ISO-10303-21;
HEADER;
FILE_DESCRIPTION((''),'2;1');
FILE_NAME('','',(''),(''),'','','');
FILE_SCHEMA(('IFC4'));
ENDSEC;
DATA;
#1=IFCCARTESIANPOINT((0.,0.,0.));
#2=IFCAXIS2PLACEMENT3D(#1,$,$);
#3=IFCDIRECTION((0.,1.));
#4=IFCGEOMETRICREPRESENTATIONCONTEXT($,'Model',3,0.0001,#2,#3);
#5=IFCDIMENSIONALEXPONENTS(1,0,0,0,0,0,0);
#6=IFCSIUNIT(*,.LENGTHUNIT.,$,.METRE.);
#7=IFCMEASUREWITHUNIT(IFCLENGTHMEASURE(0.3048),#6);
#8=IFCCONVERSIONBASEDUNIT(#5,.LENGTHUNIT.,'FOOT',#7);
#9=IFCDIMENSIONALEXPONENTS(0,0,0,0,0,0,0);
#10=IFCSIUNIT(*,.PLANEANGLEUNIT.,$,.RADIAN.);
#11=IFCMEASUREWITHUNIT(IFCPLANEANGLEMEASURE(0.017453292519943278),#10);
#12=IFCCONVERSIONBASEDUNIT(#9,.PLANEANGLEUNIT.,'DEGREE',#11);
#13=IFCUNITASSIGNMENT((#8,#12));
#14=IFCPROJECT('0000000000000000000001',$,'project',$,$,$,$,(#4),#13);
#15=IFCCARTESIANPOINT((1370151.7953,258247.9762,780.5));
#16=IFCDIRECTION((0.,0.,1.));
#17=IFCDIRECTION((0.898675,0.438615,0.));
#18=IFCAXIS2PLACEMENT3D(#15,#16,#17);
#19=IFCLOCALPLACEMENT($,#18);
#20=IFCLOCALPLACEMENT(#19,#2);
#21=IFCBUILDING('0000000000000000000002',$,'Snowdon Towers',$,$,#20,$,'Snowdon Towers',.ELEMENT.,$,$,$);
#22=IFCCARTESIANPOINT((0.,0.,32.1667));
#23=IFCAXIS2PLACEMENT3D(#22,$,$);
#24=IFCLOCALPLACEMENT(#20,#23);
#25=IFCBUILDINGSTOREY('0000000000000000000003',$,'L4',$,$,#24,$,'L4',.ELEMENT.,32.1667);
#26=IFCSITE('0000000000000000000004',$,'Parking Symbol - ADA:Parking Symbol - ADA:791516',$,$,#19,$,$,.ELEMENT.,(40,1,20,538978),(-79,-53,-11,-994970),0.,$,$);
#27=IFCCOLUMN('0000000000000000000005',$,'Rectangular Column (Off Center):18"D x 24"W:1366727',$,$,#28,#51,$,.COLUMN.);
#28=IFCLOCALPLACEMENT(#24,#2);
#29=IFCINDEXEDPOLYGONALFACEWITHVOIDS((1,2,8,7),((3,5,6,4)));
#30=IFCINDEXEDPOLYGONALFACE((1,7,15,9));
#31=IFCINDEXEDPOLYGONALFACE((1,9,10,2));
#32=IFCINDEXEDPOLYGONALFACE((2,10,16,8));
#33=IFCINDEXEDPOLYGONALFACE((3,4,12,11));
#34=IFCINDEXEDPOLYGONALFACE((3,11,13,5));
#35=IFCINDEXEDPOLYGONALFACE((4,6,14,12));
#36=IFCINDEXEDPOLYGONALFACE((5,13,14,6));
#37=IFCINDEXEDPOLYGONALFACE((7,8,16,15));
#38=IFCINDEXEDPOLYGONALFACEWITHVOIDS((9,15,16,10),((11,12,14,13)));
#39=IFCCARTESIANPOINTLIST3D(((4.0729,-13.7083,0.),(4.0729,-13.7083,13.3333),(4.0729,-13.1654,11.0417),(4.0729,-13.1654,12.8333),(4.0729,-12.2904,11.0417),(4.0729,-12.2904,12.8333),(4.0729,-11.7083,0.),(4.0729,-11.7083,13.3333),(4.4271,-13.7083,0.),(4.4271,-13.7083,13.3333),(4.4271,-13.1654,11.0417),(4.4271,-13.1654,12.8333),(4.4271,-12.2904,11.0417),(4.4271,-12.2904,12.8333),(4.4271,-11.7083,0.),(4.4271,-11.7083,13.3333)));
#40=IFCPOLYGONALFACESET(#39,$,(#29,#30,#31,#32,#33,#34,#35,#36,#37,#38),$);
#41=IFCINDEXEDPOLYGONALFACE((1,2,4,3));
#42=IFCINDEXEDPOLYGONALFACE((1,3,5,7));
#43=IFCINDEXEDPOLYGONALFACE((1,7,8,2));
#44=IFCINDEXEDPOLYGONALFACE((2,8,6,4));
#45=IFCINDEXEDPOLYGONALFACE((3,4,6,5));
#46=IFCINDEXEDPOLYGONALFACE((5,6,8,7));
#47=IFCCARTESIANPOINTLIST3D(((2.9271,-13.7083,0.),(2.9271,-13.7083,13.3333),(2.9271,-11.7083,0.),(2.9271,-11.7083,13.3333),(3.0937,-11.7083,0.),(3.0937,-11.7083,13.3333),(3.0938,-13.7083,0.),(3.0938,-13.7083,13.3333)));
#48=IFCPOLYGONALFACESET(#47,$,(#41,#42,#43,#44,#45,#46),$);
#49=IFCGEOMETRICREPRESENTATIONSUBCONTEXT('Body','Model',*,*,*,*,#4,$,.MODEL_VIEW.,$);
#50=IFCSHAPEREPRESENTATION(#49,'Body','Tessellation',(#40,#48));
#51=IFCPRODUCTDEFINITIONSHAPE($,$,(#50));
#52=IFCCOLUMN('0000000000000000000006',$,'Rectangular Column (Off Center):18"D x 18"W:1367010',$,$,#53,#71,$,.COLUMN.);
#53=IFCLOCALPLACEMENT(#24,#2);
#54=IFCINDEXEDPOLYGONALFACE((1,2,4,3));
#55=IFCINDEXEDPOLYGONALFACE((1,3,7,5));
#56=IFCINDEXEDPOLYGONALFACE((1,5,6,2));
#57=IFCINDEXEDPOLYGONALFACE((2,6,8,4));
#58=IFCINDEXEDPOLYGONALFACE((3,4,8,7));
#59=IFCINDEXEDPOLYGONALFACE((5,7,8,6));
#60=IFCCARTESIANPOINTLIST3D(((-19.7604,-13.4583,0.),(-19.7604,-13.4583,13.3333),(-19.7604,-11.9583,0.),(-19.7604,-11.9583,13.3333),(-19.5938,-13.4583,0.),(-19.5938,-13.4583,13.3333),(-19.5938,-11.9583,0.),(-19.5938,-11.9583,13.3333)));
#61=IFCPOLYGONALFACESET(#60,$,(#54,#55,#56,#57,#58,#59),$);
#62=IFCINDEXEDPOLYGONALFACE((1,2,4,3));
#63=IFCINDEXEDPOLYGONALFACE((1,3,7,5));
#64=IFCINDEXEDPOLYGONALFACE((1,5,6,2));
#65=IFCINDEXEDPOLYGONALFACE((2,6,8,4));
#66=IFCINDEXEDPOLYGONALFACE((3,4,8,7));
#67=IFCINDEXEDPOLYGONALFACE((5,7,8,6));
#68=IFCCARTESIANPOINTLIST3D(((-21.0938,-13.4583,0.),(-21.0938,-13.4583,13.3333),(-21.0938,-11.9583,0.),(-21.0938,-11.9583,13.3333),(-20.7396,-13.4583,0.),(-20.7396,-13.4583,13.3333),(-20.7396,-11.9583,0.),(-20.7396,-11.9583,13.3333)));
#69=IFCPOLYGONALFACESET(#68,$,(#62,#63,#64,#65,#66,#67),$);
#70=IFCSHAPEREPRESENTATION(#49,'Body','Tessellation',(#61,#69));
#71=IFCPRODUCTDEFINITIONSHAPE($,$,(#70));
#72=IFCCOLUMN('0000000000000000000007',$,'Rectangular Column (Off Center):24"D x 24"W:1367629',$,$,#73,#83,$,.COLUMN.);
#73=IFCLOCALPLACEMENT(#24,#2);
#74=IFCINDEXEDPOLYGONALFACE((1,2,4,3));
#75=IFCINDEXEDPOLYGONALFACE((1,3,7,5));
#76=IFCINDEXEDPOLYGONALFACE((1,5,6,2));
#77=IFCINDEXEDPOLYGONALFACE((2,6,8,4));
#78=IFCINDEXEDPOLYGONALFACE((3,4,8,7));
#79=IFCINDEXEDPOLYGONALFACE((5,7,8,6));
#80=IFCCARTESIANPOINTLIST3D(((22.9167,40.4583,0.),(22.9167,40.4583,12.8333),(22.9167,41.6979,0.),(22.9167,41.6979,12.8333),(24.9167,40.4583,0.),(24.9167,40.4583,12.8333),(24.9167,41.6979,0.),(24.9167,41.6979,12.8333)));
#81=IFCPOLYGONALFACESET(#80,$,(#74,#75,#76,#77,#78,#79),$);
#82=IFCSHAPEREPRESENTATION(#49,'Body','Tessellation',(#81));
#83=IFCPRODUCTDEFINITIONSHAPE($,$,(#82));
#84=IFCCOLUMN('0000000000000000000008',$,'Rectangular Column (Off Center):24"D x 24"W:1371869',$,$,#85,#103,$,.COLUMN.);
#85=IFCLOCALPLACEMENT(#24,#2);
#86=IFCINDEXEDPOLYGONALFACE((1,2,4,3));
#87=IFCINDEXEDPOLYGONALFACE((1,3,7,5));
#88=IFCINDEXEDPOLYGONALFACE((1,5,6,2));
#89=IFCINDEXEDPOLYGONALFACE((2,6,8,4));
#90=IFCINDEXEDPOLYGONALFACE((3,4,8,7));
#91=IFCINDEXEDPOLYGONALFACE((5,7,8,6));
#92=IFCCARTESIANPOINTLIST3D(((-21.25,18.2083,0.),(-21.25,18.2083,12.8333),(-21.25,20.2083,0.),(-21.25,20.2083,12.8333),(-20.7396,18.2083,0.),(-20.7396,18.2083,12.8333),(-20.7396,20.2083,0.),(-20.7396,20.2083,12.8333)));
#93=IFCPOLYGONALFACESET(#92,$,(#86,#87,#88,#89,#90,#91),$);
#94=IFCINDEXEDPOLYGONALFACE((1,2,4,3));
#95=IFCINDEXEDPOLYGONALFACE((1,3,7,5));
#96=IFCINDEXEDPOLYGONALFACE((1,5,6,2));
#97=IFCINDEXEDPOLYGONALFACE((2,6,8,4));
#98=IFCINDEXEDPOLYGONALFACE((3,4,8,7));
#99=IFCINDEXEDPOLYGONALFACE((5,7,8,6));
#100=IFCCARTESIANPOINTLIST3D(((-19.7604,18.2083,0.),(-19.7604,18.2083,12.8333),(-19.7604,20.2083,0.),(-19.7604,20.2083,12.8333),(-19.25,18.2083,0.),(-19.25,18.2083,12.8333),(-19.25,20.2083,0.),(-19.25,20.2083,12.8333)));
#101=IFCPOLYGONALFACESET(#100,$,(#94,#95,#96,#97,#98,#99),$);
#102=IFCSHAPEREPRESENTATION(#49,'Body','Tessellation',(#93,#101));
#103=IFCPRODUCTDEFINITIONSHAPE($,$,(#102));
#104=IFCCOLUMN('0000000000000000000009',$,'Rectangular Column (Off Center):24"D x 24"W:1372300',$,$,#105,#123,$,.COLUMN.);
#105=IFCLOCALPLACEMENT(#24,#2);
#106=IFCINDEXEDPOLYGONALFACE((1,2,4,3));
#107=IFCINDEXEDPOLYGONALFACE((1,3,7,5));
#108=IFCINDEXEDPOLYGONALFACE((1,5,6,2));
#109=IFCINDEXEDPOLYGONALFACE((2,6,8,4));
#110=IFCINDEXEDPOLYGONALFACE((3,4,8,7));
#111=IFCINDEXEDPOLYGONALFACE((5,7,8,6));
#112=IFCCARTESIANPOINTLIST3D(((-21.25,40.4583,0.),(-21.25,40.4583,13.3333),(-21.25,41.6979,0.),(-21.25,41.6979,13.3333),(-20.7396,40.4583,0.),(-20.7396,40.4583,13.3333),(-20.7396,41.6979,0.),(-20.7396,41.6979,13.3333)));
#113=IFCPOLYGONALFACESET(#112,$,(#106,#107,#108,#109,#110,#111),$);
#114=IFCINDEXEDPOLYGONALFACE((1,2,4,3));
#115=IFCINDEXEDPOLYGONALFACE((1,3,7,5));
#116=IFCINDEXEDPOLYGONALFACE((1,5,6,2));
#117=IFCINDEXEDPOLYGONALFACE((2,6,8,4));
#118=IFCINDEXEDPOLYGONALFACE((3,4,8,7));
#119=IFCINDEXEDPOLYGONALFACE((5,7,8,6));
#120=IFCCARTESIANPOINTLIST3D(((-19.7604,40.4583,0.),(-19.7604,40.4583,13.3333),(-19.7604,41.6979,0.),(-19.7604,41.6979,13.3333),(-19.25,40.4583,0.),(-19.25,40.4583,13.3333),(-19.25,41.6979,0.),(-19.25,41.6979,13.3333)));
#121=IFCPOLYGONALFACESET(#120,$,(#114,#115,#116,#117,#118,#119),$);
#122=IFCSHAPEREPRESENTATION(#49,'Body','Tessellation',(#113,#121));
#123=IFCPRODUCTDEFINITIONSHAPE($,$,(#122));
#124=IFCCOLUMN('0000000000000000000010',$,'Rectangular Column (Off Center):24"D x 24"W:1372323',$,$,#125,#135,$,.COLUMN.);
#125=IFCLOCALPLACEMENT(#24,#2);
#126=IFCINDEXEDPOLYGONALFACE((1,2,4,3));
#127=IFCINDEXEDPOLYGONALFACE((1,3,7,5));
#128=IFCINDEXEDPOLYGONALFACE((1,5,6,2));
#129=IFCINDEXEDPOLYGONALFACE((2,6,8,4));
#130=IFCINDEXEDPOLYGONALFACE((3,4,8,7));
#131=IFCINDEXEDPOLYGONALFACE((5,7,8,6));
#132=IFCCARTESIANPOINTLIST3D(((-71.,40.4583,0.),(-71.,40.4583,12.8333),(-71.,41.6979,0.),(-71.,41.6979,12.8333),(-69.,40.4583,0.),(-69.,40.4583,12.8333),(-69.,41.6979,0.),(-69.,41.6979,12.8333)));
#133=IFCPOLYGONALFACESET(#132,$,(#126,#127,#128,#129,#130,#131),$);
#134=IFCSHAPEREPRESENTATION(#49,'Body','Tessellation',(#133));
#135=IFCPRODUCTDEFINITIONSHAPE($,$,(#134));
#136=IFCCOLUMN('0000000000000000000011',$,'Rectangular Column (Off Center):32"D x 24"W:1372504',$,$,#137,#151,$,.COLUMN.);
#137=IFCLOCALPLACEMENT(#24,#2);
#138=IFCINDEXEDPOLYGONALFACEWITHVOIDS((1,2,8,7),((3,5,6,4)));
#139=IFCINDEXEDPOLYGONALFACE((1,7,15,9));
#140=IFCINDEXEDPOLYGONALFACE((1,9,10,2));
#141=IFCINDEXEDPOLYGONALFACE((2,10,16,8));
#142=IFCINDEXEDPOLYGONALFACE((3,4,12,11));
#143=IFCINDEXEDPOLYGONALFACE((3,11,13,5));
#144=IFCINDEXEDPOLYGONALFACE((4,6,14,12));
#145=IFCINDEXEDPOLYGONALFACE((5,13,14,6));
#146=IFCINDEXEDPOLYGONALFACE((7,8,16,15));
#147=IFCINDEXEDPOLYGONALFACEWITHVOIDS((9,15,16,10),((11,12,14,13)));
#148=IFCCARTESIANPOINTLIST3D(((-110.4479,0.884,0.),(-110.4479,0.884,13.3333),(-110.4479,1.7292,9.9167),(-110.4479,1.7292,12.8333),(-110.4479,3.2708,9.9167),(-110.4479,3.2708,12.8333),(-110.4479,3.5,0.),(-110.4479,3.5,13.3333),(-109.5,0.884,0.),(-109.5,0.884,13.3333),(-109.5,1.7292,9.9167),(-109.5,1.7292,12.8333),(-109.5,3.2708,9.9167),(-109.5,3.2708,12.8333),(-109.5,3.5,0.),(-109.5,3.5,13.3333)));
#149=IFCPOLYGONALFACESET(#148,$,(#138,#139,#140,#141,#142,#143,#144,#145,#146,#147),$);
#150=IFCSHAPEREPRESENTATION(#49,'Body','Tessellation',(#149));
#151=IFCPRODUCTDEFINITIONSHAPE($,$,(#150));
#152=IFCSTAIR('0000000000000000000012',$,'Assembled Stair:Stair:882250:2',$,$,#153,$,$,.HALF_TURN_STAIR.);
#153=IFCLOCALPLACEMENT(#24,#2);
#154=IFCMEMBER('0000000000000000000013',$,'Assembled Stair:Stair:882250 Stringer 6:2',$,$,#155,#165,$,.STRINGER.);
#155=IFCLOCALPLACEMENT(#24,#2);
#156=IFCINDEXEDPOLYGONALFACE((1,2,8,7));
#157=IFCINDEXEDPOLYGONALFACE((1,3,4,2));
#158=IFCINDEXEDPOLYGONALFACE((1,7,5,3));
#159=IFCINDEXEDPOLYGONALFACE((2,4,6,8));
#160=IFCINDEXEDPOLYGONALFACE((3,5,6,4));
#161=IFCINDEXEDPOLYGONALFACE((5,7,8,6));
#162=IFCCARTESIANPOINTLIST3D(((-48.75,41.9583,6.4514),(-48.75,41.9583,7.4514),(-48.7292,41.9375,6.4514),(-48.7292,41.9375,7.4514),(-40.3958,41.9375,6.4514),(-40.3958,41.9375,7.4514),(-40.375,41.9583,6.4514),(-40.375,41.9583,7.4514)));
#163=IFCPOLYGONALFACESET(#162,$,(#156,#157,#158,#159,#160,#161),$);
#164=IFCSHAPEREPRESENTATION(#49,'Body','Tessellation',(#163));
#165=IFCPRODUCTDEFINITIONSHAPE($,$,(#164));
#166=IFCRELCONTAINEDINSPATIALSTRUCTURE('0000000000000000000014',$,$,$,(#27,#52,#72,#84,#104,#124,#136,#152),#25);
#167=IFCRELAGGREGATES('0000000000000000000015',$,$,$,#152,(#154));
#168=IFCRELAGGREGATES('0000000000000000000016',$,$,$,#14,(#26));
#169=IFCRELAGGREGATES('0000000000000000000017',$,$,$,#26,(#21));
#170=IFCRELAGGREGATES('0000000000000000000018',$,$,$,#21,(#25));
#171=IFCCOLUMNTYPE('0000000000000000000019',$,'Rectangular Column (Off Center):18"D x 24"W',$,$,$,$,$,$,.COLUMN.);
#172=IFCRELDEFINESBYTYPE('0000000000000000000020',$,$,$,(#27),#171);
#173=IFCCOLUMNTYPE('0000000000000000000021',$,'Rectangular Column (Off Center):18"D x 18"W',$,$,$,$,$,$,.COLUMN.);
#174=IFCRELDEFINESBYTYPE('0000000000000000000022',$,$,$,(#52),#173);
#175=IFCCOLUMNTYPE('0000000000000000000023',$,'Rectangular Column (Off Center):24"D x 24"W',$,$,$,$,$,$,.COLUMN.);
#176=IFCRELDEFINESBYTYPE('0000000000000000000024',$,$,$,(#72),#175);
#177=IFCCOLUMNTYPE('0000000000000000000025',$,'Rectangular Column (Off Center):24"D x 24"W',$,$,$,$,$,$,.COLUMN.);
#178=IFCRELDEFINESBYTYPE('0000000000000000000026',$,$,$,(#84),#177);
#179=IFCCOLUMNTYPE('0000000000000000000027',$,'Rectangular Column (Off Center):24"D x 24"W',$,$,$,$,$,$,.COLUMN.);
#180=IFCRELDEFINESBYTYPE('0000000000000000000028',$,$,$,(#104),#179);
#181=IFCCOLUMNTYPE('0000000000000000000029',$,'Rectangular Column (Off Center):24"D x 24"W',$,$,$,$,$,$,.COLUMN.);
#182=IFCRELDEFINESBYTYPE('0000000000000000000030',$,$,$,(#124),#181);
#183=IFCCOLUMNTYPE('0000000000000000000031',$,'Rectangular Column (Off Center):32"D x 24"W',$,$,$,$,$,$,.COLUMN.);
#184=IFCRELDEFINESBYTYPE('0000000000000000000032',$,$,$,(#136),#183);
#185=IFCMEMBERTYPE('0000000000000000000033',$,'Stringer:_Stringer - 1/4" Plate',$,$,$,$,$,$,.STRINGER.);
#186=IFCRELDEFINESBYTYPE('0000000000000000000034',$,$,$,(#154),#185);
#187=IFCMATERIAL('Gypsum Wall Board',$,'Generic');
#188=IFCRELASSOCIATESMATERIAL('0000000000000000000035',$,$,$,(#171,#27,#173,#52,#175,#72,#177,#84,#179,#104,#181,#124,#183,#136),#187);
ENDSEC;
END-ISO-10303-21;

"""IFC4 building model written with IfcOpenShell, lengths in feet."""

from ifc_helpers import new_model, entity, si_unit, converted_unit, direction, frame, origin, place, context, subcontext, project, spatial, indexed_curve, outline, extrude, source, transform, mapped, material, type_object, type_shapes, element, aggregate, save


model = new_model("IFC4")

# Units and contexts
model_context = context("Model", 3, precision=0.0001, world=origin(), true_north=direction((0.0, 1.0)))
body_context = subcontext(model_context, "Body", "Model", "MODEL_VIEW")
ifc_project = project(units=[converted_unit("LENGTHUNIT", "FOOT", entity("IfcLengthMeasure", 0.3048), si_unit("LENGTHUNIT", "METRE"), dimensions=[1, 0, 0, 0, 0, 0, 0]), converted_unit("PLANEANGLEUNIT", "DEGREE", entity("IfcPlaneAngleMeasure", 0.017453292519943278), si_unit("PLANEANGLEUNIT", "RADIAN"), dimensions=[0, 0, 0, 0, 0, 0, 0])], contexts=[model_context])

# Site, building, storey
site_placement = place(None, frame((1370151.7953, 258247.9762, 780.5), z_axis=(0.0, 0.0, 1.0), x_axis=(0.898675, 0.438615, 0.0)))
site = spatial("IfcSite", under=ifc_project, at=site_placement, Name="Parking Symbol - ADA:Parking Symbol - ADA:791516", CompositionType="ELEMENT", RefLatitude=(40, 1, 20, 538978), RefLongitude=(-79, -53, -11, -994970), RefElevation=0.0)
building_placement = place(site_placement, origin())
building = spatial("IfcBuilding", under=site, at=building_placement, Name="Snowdon Towers", LongName="Snowdon Towers", CompositionType="ELEMENT")
storey_placement = place(building_placement, frame((0.0, 0.0, 32.1667)))
storey = spatial("IfcBuildingStorey", under=building, at=storey_placement, Name="L4", LongName="L4", CompositionType="ELEMENT", Elevation=32.1667)

# Shared definitions
ifc_material_1 = material(Name="Gypsum Wall Board", Category="Generic")

# Column, opening
column_type_1 = type_object("IfcColumnType", Name="Rectangular Column (Off Center):18\"D x 24\"W", PredefinedType="COLUMN", material=ifc_material_1)
shared_shape_1 = source(origin(), body_context, "Body", "SweptSolid", [
    extrude(outline(indexed_curve([(-0.1771, -1.0), (0.1771, -1.0), (0.1771, 1.0), (-0.1771, 1.0), (-0.1771, -1.0)], self_intersect=False)), frame((4.25, -12.7083, 32.1667), z_axis=(0.0, 0.0, 1.0), x_axis=(-1.0, 0.0, 0.0)), (0.0, 0.0, 1.0), 13.3333),
    extrude(outline(indexed_curve([(-0.0833, -1.0), (0.0833, -1.0), (0.0833, 1.0), (-0.0833, 1.0), (-0.0833, -1.0)], self_intersect=False)), frame((3.0104, -12.7083, 32.1667)), (0.0, 0.0, 1.0), 13.3333),
])
type_shapes(column_type_1, [shared_shape_1])
column_1_placement = place(storey_placement, frame((0.0, 0.0, -32.1667)))
column_1 = element("IfcColumn", 1, at=column_1_placement, inside=storey, type_object=column_type_1, material=ifc_material_1, Name="Rectangular Column (Off Center):18\"D x 24\"W:1366727", PredefinedType="COLUMN", context=body_context, shape_type="MappedRepresentation", body=[
    mapped(shared_shape_1, transform((0.0, 0.0, 0.0), scale=1.0)),
])
opening_1_placement = place(storey_placement, frame((0.0, 0.0, -32.1667)))
element("IfcOpeningElement", 2, at=opening_1_placement, cuts=column_1, PredefinedType="OPENING", context=body_context, shape_type="SweptSolid", body=[
    extrude(outline(indexed_curve([(-0.8958, -0.4375), (0.8958, -0.4375), (0.8958, 0.4375), (-0.8958, 0.4375), (-0.8958, -0.4375)], self_intersect=False)), frame((4.4271, -12.7279, 44.1042), z_axis=(-1.0, 0.0, 0.0), x_axis=(0.0, 0.0, 1.0)), (0.0, 0.0, 1.0), 0.3542),
])

# Column
column_type_2 = type_object("IfcColumnType", Name="Rectangular Column (Off Center):18\"D x 18\"W", PredefinedType="COLUMN", material=ifc_material_1)
shared_shape_2 = source(origin(), body_context, "Body", "SweptSolid", [
    extrude(outline(indexed_curve([(-0.0833, -0.75), (0.0833, -0.75), (0.0833, 0.75), (-0.0833, 0.75), (-0.0833, -0.75)], self_intersect=False)), frame((-19.6771, -12.7083, 32.1667), z_axis=(0.0, 0.0, 1.0), x_axis=(-1.0, 0.0, 0.0)), (0.0, 0.0, 1.0), 13.3333),
    extrude(outline(indexed_curve([(-0.1771, -0.75), (0.1771, -0.75), (0.1771, 0.75), (-0.1771, 0.75), (-0.1771, -0.75)], self_intersect=False)), frame((-20.9167, -12.7083, 32.1667)), (0.0, 0.0, 1.0), 13.3333),
])
type_shapes(column_type_2, [shared_shape_2])
column_2_placement = place(storey_placement, frame((0.0, 0.0, -32.1667)))
element("IfcColumn", 3, at=column_2_placement, inside=storey, type_object=column_type_2, material=ifc_material_1, Name="Rectangular Column (Off Center):18\"D x 18\"W:1367010", PredefinedType="COLUMN", context=body_context, shape_type="MappedRepresentation", body=[
    mapped(shared_shape_2, transform((0.0, 0.0, 0.0), scale=1.0)),
])

# Columns
column_type_3 = type_object("IfcColumnType", Name="Rectangular Column (Off Center):24\"D x 24\"W", PredefinedType="COLUMN", material=ifc_material_1)
shared_shape_3 = source(origin(), body_context, "Body", "SweptSolid", [
    extrude(outline(indexed_curve([(-0.6198, -1.0), (0.6198, -1.0), (0.6198, 1.0), (-0.6198, 1.0), (-0.6198, -1.0)], self_intersect=False)), frame((23.9167, 41.0781, 32.1667), z_axis=(0.0, 0.0, 1.0), x_axis=(0.0, 1.0, 0.0)), (0.0, 0.0, 1.0), 12.8333),
])
type_shapes(column_type_3, [shared_shape_3])
column_3_placement = place(storey_placement, frame((0.0, 0.0, -32.1667)))
element("IfcColumn", 4, at=column_3_placement, inside=storey, type_object=column_type_3, material=ifc_material_1, Name="Rectangular Column (Off Center):24\"D x 24\"W:1367629", PredefinedType="COLUMN", context=body_context, shape_type="MappedRepresentation", body=[
    mapped(shared_shape_3, transform((0.0, 0.0, 0.0), scale=1.0)),
])
column_type_4 = type_object("IfcColumnType", Name="Rectangular Column (Off Center):24\"D x 24\"W", PredefinedType="COLUMN", material=ifc_material_1)
shared_shape_4 = source(origin(), body_context, "Body", "SweptSolid", [
    extrude(outline(indexed_curve([(-0.2552, -1.0), (0.2552, -1.0), (0.2552, 1.0), (-0.2552, 1.0), (-0.2552, -1.0)], self_intersect=False)), frame((-20.9948, 19.2083, 32.1667)), (0.0, 0.0, 1.0), 12.8333),
    extrude(outline(indexed_curve([(-0.2552, -1.0), (0.2552, -1.0), (0.2552, 1.0), (-0.2552, 1.0), (-0.2552, -1.0)], self_intersect=False)), frame((-19.5052, 19.2083, 32.1667), z_axis=(0.0, 0.0, 1.0), x_axis=(-1.0, 0.0, 0.0)), (0.0, 0.0, 1.0), 12.8333),
])
type_shapes(column_type_4, [shared_shape_4])
column_4_placement = place(storey_placement, frame((0.0, 0.0, -32.1667)))
element("IfcColumn", 5, at=column_4_placement, inside=storey, type_object=column_type_4, material=ifc_material_1, Name="Rectangular Column (Off Center):24\"D x 24\"W:1371869", PredefinedType="COLUMN", context=body_context, shape_type="MappedRepresentation", body=[
    mapped(shared_shape_4, transform((0.0, 0.0, 0.0), scale=1.0)),
])
column_type_5 = type_object("IfcColumnType", Name="Rectangular Column (Off Center):24\"D x 24\"W", PredefinedType="COLUMN", material=ifc_material_1)
shared_shape_5 = source(origin(), body_context, "Body", "SweptSolid", [
    extrude(outline(indexed_curve([(-0.6198, -0.2552), (0.6198, -0.2552), (0.6198, 0.2552), (-0.6198, 0.2552), (-0.6198, -0.2552)], self_intersect=False)), frame((-20.9948, 41.0781, 32.1667), z_axis=(0.0, 0.0, 1.0), x_axis=(0.0, 1.0, 0.0)), (0.0, 0.0, 1.0), 13.3333),
    extrude(outline(indexed_curve([(-0.6198, -0.2552), (0.6198, -0.2552), (0.6198, 0.2552), (-0.6198, 0.2552), (-0.6198, -0.2552)], self_intersect=False)), frame((-19.5052, 41.0781, 32.1667), z_axis=(0.0, 0.0, 1.0), x_axis=(0.0, 1.0, 0.0)), (0.0, 0.0, 1.0), 13.3333),
])
type_shapes(column_type_5, [shared_shape_5])
column_5_placement = place(storey_placement, frame((0.0, 0.0, -32.1667)))
element("IfcColumn", 6, at=column_5_placement, inside=storey, type_object=column_type_5, material=ifc_material_1, Name="Rectangular Column (Off Center):24\"D x 24\"W:1372300", PredefinedType="COLUMN", context=body_context, shape_type="MappedRepresentation", body=[
    mapped(shared_shape_5, transform((0.0, 0.0, 0.0), scale=1.0)),
])
column_type_6 = type_object("IfcColumnType", Name="Rectangular Column (Off Center):24\"D x 24\"W", PredefinedType="COLUMN", material=ifc_material_1)
shared_shape_6 = source(origin(), body_context, "Body", "SweptSolid", [
    extrude(outline(indexed_curve([(-0.6198, -1.0), (0.6198, -1.0), (0.6198, 1.0), (-0.6198, 1.0), (-0.6198, -1.0)], self_intersect=False)), frame((-70.0, 41.0781, 32.1667), z_axis=(0.0, 0.0, 1.0), x_axis=(0.0, 1.0, 0.0)), (0.0, 0.0, 1.0), 12.8333),
])
type_shapes(column_type_6, [shared_shape_6])
column_6_placement = place(storey_placement, frame((0.0, 0.0, -32.1667)))
element("IfcColumn", 7, at=column_6_placement, inside=storey, type_object=column_type_6, material=ifc_material_1, Name="Rectangular Column (Off Center):24\"D x 24\"W:1372323", PredefinedType="COLUMN", context=body_context, shape_type="MappedRepresentation", body=[
    mapped(shared_shape_6, transform((0.0, 0.0, 0.0), scale=1.0)),
])

# Column, opening
column_type_7 = type_object("IfcColumnType", Name="Rectangular Column (Off Center):32\"D x 24\"W", PredefinedType="COLUMN", material=ifc_material_1)
shared_shape_7 = source(origin(), body_context, "Body", "SweptSolid", [
    extrude(outline(indexed_curve([(-1.308, -0.474), (1.308, -0.474), (1.308, 0.474), (-1.308, 0.474), (-1.308, -0.474)], self_intersect=False)), frame((-109.974, 2.192, 32.1667), z_axis=(0.0, 0.0, 1.0), x_axis=(0.0, -1.0, 0.0)), (0.0, 0.0, 1.0), 13.3333),
])
type_shapes(column_type_7, [shared_shape_7])
column_7_placement = place(storey_placement, frame((0.0, 0.0, -32.1667)))
column_7 = element("IfcColumn", 8, at=column_7_placement, inside=storey, type_object=column_type_7, material=ifc_material_1, Name="Rectangular Column (Off Center):32\"D x 24\"W:1372504", PredefinedType="COLUMN", context=body_context, shape_type="MappedRepresentation", body=[
    mapped(shared_shape_7, transform((0.0, 0.0, 0.0), scale=1.0)),
])
opening_2_placement = place(storey_placement, frame((0.0, 0.0, -32.1667)))
element("IfcOpeningElement", 9, at=opening_2_placement, cuts=column_7, PredefinedType="OPENING", context=body_context, shape_type="SweptSolid", body=[
    extrude(outline(indexed_curve([(-1.4583, -0.7708), (1.4583, -0.7708), (1.4583, 0.7708), (-1.4583, 0.7708), (-1.4583, -0.7708)], self_intersect=False)), frame((-110.4479, 2.5, 43.5417), z_axis=(1.0, 0.0, 0.0), x_axis=(0.0, 0.0, 1.0)), (0.0, 0.0, 1.0), 0.9479),
])

# Stair, member
stair_placement = place(storey_placement, origin())
stair = element("IfcStair", 10, at=stair_placement, inside=storey, Name="Assembled Stair:Stair:882250:2", PredefinedType="HALF_TURN_STAIR")
member_type = type_object("IfcMemberType", Name="Stringer:_Stringer - 1/4\" Plate", PredefinedType="STRINGER")
member_1_placement = place(stair_placement, origin())
member_1 = element("IfcMember", 11, at=member_1_placement, type_object=member_type, Name="Assembled Stair:Stair:882250 Stringer 6:2", PredefinedType="STRINGER", context=body_context, shape_type="SweptSolid", body=[
    extrude(outline(indexed_curve([(-4.1875, -0.0104), (4.1875, -0.0104), (4.1667, 0.0104), (-4.1667, 0.0104), (-4.1875, -0.0104)], self_intersect=False)), frame((-44.5625, 41.9479, 6.4514), z_axis=(0.0, 0.0, 1.0), x_axis=(-1.0, 0.0, 0.0)), (0.0, 0.0, 1.0), 1.0),
])
aggregate(stair, [member_1])

save(model, "model.ifc")
